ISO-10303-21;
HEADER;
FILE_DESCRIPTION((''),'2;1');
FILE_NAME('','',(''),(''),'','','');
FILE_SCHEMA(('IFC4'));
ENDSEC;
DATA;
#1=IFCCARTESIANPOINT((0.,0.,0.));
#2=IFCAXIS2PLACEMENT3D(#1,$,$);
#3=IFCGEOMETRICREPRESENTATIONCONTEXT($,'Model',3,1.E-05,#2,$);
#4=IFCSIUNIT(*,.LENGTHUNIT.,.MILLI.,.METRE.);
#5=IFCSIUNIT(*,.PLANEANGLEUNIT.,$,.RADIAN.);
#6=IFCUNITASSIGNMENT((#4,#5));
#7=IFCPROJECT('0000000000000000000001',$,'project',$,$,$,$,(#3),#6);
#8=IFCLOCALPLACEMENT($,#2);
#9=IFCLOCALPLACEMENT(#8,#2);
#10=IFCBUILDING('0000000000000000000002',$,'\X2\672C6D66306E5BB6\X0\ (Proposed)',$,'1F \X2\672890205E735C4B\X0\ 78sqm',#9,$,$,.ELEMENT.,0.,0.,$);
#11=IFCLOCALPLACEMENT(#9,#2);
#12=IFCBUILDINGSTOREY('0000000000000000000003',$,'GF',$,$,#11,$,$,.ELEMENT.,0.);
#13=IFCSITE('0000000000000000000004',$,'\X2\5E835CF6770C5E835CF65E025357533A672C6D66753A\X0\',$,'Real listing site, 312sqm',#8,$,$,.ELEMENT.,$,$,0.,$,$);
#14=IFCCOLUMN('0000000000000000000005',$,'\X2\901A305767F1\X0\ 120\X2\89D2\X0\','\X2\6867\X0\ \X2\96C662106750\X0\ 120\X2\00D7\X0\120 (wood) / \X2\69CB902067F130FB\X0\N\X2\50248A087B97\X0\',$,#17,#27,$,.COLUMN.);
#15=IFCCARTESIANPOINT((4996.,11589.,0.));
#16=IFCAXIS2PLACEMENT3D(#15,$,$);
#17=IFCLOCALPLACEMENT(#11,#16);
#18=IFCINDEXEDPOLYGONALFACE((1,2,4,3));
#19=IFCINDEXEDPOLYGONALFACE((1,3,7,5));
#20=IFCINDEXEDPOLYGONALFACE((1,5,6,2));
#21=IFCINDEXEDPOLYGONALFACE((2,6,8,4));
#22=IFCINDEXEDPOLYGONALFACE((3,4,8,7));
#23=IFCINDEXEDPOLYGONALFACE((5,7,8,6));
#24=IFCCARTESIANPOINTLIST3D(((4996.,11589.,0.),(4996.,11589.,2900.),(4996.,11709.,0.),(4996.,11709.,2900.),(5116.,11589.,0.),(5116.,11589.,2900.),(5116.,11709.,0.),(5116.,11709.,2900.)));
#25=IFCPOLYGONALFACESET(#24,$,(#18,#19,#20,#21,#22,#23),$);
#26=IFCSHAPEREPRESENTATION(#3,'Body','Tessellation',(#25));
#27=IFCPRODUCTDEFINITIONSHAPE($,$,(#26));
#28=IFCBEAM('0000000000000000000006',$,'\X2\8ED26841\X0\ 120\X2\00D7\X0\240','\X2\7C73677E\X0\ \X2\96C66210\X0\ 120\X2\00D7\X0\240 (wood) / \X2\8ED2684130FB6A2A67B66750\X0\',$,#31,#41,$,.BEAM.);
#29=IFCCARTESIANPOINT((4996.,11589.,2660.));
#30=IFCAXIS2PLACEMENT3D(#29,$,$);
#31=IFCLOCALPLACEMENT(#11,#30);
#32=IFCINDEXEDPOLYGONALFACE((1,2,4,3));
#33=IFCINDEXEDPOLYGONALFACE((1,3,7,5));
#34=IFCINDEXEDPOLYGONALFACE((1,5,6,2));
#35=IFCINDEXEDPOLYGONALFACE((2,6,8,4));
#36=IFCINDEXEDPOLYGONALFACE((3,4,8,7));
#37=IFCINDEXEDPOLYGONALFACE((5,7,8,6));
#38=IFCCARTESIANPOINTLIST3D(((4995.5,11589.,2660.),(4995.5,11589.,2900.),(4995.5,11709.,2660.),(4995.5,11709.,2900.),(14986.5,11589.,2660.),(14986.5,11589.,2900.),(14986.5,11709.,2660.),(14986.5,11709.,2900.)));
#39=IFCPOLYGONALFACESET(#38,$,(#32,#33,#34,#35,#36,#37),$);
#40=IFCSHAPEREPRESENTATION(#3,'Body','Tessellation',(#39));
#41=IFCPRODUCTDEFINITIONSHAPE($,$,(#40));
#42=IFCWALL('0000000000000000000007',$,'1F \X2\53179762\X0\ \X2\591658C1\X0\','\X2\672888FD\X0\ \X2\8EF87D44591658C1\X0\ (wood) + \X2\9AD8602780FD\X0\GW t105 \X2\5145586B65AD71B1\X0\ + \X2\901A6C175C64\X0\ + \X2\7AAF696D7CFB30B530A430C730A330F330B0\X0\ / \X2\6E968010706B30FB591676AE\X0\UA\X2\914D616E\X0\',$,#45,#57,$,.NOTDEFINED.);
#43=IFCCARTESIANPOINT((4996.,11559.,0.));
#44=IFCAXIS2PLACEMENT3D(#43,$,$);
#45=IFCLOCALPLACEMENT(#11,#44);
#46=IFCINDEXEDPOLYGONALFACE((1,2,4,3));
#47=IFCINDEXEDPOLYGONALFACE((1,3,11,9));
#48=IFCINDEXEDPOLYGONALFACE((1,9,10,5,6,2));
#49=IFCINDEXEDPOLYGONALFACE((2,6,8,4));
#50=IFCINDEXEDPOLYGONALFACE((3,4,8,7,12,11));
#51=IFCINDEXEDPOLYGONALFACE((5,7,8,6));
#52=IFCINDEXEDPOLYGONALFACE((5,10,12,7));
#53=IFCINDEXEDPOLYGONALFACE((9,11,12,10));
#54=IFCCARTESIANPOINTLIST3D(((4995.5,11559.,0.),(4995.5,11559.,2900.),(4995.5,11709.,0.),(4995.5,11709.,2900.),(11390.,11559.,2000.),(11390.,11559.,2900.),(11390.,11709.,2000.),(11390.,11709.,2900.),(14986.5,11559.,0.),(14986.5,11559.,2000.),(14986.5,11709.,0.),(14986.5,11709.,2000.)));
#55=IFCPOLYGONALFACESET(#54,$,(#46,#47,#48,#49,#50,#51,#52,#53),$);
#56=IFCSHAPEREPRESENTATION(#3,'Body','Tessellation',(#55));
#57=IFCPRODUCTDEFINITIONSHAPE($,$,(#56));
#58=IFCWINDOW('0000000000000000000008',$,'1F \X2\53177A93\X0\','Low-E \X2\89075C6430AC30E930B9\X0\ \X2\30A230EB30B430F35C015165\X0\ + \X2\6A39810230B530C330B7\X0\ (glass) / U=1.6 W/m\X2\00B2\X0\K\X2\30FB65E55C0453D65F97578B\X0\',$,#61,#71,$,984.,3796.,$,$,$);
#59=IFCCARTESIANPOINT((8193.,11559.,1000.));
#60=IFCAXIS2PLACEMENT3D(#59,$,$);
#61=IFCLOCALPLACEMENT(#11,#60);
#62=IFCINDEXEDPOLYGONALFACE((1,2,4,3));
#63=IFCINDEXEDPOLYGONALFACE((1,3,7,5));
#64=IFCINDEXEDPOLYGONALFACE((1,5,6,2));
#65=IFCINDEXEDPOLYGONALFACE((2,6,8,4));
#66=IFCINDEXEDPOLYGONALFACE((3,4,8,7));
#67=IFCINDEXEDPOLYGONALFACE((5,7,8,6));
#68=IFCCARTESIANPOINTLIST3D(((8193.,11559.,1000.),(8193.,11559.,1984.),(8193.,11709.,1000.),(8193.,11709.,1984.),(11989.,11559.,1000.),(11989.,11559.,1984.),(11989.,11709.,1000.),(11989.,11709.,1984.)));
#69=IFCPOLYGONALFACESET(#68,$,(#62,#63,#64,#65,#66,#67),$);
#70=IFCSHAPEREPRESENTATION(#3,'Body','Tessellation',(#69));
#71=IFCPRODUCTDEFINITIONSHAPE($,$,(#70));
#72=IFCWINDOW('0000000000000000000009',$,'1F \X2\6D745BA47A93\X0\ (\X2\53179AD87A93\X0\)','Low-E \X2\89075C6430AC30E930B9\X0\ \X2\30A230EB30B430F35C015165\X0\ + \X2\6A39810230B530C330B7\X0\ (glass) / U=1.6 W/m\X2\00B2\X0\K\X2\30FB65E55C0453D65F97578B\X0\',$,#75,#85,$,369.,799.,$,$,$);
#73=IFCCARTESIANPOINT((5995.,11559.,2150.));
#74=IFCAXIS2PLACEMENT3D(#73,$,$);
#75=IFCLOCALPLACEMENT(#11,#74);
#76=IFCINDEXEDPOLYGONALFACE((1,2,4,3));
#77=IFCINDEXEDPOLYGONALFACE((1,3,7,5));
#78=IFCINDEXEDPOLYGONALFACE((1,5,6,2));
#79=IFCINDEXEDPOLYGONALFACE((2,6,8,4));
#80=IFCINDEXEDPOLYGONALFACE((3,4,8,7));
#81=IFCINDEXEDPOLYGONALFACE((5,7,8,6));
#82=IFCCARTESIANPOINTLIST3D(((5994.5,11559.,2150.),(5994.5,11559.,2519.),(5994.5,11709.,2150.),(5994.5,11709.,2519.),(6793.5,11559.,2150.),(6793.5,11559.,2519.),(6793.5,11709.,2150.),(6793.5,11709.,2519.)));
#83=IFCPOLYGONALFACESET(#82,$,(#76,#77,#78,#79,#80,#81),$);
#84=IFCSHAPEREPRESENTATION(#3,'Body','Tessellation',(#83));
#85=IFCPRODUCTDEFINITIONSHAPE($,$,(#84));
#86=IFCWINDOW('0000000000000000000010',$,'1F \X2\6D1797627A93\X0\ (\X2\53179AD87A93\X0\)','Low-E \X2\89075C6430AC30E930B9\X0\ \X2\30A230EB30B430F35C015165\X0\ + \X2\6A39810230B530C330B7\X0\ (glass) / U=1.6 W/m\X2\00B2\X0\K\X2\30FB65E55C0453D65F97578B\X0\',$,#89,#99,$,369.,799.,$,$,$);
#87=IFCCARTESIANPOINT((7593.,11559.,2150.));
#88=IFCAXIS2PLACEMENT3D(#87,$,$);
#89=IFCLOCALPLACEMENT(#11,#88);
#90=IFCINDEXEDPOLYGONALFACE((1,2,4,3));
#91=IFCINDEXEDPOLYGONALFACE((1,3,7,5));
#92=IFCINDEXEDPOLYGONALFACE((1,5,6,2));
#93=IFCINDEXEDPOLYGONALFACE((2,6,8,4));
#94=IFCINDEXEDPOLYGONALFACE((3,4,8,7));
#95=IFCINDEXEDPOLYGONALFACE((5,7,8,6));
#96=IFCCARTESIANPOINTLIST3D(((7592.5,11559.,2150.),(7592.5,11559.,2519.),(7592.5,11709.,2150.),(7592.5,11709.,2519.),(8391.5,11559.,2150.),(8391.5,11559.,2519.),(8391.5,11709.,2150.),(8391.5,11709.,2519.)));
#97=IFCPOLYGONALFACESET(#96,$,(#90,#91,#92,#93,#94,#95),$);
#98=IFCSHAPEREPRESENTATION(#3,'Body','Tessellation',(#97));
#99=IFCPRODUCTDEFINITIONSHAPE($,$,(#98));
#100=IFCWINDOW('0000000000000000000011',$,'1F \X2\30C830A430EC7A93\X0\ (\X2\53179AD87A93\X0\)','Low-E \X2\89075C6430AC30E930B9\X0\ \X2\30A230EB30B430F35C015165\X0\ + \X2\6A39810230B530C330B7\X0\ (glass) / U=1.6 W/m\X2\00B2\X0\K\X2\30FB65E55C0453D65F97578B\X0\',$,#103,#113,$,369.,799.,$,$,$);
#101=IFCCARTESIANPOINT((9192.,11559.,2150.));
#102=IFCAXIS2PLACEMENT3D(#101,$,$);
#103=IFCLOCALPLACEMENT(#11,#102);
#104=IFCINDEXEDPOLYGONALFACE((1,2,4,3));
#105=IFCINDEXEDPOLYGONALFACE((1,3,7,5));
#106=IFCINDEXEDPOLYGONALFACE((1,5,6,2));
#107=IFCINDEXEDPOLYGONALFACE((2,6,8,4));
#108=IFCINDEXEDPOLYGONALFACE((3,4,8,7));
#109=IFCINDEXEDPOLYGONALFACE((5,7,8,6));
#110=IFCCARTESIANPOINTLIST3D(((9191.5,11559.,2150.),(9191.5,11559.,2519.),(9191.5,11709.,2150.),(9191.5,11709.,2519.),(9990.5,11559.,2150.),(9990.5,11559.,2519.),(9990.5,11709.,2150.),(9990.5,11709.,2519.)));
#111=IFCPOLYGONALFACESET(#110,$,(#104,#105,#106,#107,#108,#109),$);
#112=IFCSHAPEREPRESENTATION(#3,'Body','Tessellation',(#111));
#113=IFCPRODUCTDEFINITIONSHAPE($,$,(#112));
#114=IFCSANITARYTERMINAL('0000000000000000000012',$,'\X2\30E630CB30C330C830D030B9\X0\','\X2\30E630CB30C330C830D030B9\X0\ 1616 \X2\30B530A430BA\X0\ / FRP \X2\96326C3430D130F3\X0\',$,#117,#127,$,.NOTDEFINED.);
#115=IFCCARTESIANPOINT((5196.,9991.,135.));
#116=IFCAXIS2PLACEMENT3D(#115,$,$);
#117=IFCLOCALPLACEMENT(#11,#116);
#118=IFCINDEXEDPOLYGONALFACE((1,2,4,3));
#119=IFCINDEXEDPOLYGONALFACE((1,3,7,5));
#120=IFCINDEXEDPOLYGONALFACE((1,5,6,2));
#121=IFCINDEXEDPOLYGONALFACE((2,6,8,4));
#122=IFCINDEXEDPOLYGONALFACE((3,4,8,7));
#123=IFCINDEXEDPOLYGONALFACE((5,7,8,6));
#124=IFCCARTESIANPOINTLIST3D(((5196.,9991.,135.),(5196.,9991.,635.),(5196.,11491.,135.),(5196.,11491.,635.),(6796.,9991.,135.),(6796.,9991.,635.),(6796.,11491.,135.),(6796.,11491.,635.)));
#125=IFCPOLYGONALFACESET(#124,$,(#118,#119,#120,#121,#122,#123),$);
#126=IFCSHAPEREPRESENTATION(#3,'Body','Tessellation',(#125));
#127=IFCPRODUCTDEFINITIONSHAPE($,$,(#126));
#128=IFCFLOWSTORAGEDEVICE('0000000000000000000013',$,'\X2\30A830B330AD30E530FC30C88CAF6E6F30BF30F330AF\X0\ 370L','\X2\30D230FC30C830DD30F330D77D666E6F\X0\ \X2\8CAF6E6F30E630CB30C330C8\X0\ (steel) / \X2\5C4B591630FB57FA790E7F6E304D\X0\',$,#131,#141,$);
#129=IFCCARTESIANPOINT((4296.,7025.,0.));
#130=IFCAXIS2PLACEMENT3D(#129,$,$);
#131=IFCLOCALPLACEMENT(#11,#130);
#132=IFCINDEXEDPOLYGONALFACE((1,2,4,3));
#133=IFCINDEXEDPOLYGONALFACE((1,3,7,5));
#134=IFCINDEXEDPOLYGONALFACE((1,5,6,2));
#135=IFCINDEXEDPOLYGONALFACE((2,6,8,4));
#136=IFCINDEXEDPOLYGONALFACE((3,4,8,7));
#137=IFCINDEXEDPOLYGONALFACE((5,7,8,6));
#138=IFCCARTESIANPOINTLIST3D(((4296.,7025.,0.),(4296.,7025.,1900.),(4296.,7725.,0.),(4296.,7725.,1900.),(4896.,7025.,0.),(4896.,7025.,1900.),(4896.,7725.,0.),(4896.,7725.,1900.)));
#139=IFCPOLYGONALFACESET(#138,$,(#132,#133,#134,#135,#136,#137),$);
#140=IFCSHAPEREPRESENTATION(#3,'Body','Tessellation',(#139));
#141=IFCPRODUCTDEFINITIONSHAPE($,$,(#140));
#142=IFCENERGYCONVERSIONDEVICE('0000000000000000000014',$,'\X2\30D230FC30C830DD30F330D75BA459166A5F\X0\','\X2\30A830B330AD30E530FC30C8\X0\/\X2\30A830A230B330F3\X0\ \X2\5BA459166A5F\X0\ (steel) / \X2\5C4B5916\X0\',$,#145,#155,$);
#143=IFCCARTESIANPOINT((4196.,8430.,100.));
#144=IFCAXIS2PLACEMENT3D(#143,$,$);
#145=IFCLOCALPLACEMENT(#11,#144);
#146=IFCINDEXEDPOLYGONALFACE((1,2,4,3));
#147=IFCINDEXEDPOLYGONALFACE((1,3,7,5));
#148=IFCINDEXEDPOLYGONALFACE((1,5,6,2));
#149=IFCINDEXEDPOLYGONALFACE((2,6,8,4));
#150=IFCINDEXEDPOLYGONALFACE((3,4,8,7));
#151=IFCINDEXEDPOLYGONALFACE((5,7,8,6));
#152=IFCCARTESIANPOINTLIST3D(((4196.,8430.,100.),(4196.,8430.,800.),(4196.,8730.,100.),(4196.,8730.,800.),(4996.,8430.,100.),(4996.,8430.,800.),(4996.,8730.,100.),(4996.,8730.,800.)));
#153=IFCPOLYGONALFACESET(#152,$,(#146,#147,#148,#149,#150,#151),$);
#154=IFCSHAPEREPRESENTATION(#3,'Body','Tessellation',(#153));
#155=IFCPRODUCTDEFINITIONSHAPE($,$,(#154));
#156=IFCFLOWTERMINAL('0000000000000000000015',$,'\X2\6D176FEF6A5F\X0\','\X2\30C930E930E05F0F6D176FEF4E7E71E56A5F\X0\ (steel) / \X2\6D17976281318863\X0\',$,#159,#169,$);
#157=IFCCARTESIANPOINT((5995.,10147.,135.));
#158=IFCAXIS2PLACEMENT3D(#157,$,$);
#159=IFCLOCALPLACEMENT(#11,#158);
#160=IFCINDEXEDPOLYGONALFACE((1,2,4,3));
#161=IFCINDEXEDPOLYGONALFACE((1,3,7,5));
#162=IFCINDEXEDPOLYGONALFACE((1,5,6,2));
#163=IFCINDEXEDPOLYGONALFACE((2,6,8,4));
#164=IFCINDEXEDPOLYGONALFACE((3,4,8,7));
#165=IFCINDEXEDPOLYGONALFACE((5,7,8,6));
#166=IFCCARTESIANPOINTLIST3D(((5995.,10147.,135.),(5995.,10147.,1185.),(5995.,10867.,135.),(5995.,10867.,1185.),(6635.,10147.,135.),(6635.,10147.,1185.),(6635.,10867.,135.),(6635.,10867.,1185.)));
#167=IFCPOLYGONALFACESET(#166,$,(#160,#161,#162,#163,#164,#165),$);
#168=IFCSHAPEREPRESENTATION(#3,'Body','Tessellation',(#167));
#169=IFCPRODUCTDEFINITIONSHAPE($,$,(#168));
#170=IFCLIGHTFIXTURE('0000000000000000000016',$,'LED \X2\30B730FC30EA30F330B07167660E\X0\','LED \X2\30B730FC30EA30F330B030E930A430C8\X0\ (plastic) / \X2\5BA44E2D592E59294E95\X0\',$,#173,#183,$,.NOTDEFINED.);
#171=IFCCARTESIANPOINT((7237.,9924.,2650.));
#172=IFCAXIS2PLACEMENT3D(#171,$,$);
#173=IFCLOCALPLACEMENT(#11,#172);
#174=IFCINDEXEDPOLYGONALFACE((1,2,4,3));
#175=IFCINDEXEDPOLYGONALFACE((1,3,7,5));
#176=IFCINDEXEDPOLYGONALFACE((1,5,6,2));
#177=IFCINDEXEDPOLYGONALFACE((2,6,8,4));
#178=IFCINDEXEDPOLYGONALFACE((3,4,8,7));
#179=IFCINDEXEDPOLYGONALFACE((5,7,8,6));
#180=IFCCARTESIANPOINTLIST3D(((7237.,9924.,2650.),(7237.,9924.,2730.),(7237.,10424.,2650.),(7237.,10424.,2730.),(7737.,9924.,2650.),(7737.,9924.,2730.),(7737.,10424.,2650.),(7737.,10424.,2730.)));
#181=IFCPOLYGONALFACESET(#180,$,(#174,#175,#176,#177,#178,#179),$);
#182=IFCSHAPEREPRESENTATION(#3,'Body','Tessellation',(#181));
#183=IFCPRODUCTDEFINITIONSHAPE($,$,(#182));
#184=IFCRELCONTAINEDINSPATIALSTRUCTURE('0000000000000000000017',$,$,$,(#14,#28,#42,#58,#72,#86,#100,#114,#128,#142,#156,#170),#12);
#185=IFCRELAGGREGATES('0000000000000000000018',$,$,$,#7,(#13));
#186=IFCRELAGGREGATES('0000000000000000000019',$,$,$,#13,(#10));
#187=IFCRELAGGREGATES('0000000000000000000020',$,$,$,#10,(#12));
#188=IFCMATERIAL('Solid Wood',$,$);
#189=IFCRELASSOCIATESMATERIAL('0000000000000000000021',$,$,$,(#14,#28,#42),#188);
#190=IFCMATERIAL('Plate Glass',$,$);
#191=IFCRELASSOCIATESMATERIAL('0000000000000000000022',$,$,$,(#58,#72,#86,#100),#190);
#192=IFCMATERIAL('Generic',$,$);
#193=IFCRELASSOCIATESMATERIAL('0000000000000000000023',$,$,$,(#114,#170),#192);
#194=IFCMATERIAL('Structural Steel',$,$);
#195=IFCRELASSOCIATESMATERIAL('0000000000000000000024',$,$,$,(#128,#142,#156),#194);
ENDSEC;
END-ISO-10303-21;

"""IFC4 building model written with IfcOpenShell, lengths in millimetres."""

from ifc_helpers import new_model, si_unit, frame, frame_2d, origin, place, context, project, spatial, rectangle, extrude, material, element, fill, save


model = new_model("IFC4")

# Units and contexts
model_context = context("Model", 3, precision=1e-05, world=origin())
ifc_project = project(units=[si_unit("LENGTHUNIT", "METRE", prefix="MILLI"), si_unit("PLANEANGLEUNIT", "RADIAN")], contexts=[model_context])

# Site, building, storey
site_placement = place(None, origin())
site = spatial("IfcSite", under=ifc_project, at=site_placement, Name="広島県広島市南区本浦町", ObjectType="Real listing site, 312sqm", CompositionType="ELEMENT", RefElevation=0.0)
building_placement = place(site_placement, origin())
building = spatial("IfcBuilding", under=site, at=building_placement, Name="本浦の家 (Proposed)", ObjectType="1F 木造平屋 78sqm", CompositionType="ELEMENT", ElevationOfRefHeight=0.0, ElevationOfTerrain=0.0)
storey_placement = place(building_placement, origin())
storey = spatial("IfcBuildingStorey", under=building, at=storey_placement, Name="GF", CompositionType="ELEMENT", Elevation=0.0)

# Column
ifc_material_1 = material(Name="Solid Wood")
column_1_placement = place(storey_placement, frame((4996.0, 11589.0, 0.0)))
element("IfcColumn", 1, at=column_1_placement, inside=storey, material=ifc_material_1, Name="通し柱 120角", Description="桧 集成材 120×120 (wood) / 構造柱・N値計算", PredefinedType="COLUMN", context=model_context, shape_type="SweptSolid", body=[
    extrude(rectangle(XDim=120.0, YDim=120.0, at=frame_2d((60.0, 60.0))), frame((4996.0, 11589.0, 0.0)), (0.0, 0.0, 1.0), 2900.0),
])

# Beam
beam_1_placement = place(storey_placement, frame((4996.0, 11589.0, 2660.0)))
element("IfcBeam", 2, at=beam_1_placement, inside=storey, material=ifc_material_1, Name="軒桁 120×240", Description="米松 集成 120×240 (wood) / 軒桁・横架材", PredefinedType="BEAM", context=model_context, shape_type="SweptSolid", body=[
    extrude(rectangle(XDim=9991.0, YDim=120.0, at=frame_2d((4995.0, 60.0))), frame((4996.0, 11589.0, 2660.0)), (0.0, 0.0, 1.0), 240.0),
])

# Wall, openings, windows
wall_1_placement = place(storey_placement, frame((4996.0, 11559.0, 0.0)))
wall_1 = element("IfcWall", 3, at=wall_1_placement, inside=storey, material=ifc_material_1, Name="1F 北面 外壁", Description="木製 軸組外壁 (wood) + 高性能GW t105 充填断熱 + 通気層 + 窯業系サイディング / 準耐火・外皮UA配慮", PredefinedType="NOTDEFINED", context=model_context, shape_type="SweptSolid", body=[
    extrude(rectangle(XDim=9991.0, YDim=150.0, at=frame_2d((4995.0, 75.0))), frame((4996.0, 11559.0, 0.0)), (0.0, 0.0, 1.0), 2900.0),
])
opening_1_placement = place(storey_placement, frame((8193.0, 11559.0, 1000.0)))
opening_1 = element("IfcOpeningElement", 4, at=opening_1_placement, cuts=wall_1, PredefinedType="NOTDEFINED", context=model_context, shape_type="SweptSolid", body=[
    extrude(rectangle(XDim=3796.0, YDim=150.0, at=frame_2d((1898.0, 75.0))), frame((8193.0, 11559.0, 1000.0)), (0.0, 0.0, 1.0), 984.0),
])
opening_2_placement = place(storey_placement, frame((5995.0, 11559.0, 2150.0)))
opening_2 = element("IfcOpeningElement", 5, at=opening_2_placement, cuts=wall_1, PredefinedType="NOTDEFINED", context=model_context, shape_type="SweptSolid", body=[
    extrude(rectangle(XDim=799.0, YDim=150.0, at=frame_2d((399.0, 75.0))), frame((5995.0, 11559.0, 2150.0)), (0.0, 0.0, 1.0), 369.0),
])
opening_3_placement = place(storey_placement, frame((7593.0, 11559.0, 2150.0)))
opening_3 = element("IfcOpeningElement", 6, at=opening_3_placement, cuts=wall_1, PredefinedType="NOTDEFINED", context=model_context, shape_type="SweptSolid", body=[
    extrude(rectangle(XDim=799.0, YDim=150.0, at=frame_2d((399.0, 75.0))), frame((7593.0, 11559.0, 2150.0)), (0.0, 0.0, 1.0), 369.0),
])
opening_4_placement = place(storey_placement, frame((9192.0, 11559.0, 2150.0)))
opening_4 = element("IfcOpeningElement", 7, at=opening_4_placement, cuts=wall_1, PredefinedType="NOTDEFINED", context=model_context, shape_type="SweptSolid", body=[
    extrude(rectangle(XDim=799.0, YDim=150.0, at=frame_2d((399.0, 75.0))), frame((9192.0, 11559.0, 2150.0)), (0.0, 0.0, 1.0), 369.0),
])
ifc_material_2 = material(Name="Plate Glass")
window_1_placement = place(storey_placement, frame((8193.0, 11559.0, 1000.0)))
window_1 = element("IfcWindow", 8, at=window_1_placement, inside=storey, material=ifc_material_2, Name="1F 北窓", Description="Low-E 複層ガラス アルゴン封入 + 樹脂サッシ (glass) / U=1.6 W/m²K・日射取得型", OverallHeight=984.0, OverallWidth=3796.0, context=model_context, shape_type="SweptSolid", body=[
    extrude(rectangle(XDim=3796.0, YDim=150.0, at=frame_2d((1898.0, 75.0))), frame((8193.0, 11559.0, 1000.0)), (0.0, 0.0, 1.0), 984.0),
])
fill(opening_1, window_1)
window_2_placement = place(storey_placement, frame((5995.0, 11559.0, 2150.0)))
window_2 = element("IfcWindow", 9, at=window_2_placement, inside=storey, material=ifc_material_2, Name="1F 浴室窓 (北高窓)", Description="Low-E 複層ガラス アルゴン封入 + 樹脂サッシ (glass) / U=1.6 W/m²K・日射取得型", OverallHeight=369.0, OverallWidth=799.0, context=model_context, shape_type="SweptSolid", body=[
    extrude(rectangle(XDim=799.0, YDim=150.0, at=frame_2d((399.0, 75.0))), frame((5995.0, 11559.0, 2150.0)), (0.0, 0.0, 1.0), 369.0),
])
fill(opening_2, window_2)
window_3_placement = place(storey_placement, frame((7593.0, 11559.0, 2150.0)))
window_3 = element("IfcWindow", 10, at=window_3_placement, inside=storey, material=ifc_material_2, Name="1F 洗面窓 (北高窓)", Description="Low-E 複層ガラス アルゴン封入 + 樹脂サッシ (glass) / U=1.6 W/m²K・日射取得型", OverallHeight=369.0, OverallWidth=799.0, context=model_context, shape_type="SweptSolid", body=[
    extrude(rectangle(XDim=799.0, YDim=150.0, at=frame_2d((399.0, 75.0))), frame((7593.0, 11559.0, 2150.0)), (0.0, 0.0, 1.0), 369.0),
])
fill(opening_3, window_3)
window_4_placement = place(storey_placement, frame((9192.0, 11559.0, 2150.0)))
window_4 = element("IfcWindow", 11, at=window_4_placement, inside=storey, material=ifc_material_2, Name="1F トイレ窓 (北高窓)", Description="Low-E 複層ガラス アルゴン封入 + 樹脂サッシ (glass) / U=1.6 W/m²K・日射取得型", OverallHeight=369.0, OverallWidth=799.0, context=model_context, shape_type="SweptSolid", body=[
    extrude(rectangle(XDim=799.0, YDim=150.0, at=frame_2d((399.0, 75.0))), frame((9192.0, 11559.0, 2150.0)), (0.0, 0.0, 1.0), 369.0),
])
fill(opening_4, window_4)

# Shared definitions
ifc_material_3 = material(Name="Structural Steel")

# Sanitary terminal
ifc_material_4 = material(Name="Generic")
sanitary_terminal_placement = place(storey_placement, frame((5196.0, 9991.0, 135.0)))
element("IfcSanitaryTerminal", 12, at=sanitary_terminal_placement, inside=storey, material=ifc_material_4, Name="ユニットバス", Description="ユニットバス 1616 サイズ / FRP 防水パン", PredefinedType="NOTDEFINED", context=model_context, shape_type="SweptSolid", body=[
    extrude(rectangle(XDim=1600.0, YDim=1500.0, at=frame_2d((800.0, 750.0))), frame((5196.0, 9991.0, 135.0)), (0.0, 0.0, 1.0), 500.0),
])

# Flow storage device
flow_storage_device_placement = place(storey_placement, frame((4296.0, 7025.0, 0.0)))
element("IfcFlowStorageDevice", 13, at=flow_storage_device_placement, inside=storey, material=ifc_material_3, Name="エコキュート貯湯タンク 370L", Description="ヒートポンプ給湯 貯湯ユニット (steel) / 屋外・基礎置き", context=model_context, shape_type="SweptSolid", body=[
    extrude(rectangle(XDim=600.0, YDim=700.0, at=frame_2d((300.0, 350.0))), frame((4296.0, 7025.0, 0.0)), (0.0, 0.0, 1.0), 1900.0),
])

# Energy conversion device
energy_conversion_device_placement = place(storey_placement, frame((4196.0, 8430.0, 100.0)))
element("IfcEnergyConversionDevice", 14, at=energy_conversion_device_placement, inside=storey, material=ifc_material_3, Name="ヒートポンプ室外機", Description="エコキュート/エアコン 室外機 (steel) / 屋外", context=model_context, shape_type="SweptSolid", body=[
    extrude(rectangle(XDim=800.0, YDim=300.0, at=frame_2d((400.0, 150.0))), frame((4196.0, 8430.0, 100.0)), (0.0, 0.0, 1.0), 700.0),
])

# Flow terminal
flow_terminal_placement = place(storey_placement, frame((5995.0, 10147.0, 135.0)))
element("IfcFlowTerminal", 15, at=flow_terminal_placement, inside=storey, material=ifc_material_3, Name="洗濯機", Description="ドラム式洗濯乾燥機 (steel) / 洗面脱衣", context=model_context, shape_type="SweptSolid", body=[
    extrude(rectangle(XDim=640.0, YDim=720.0, at=frame_2d((320.0, 360.0))), frame((5995.0, 10147.0, 135.0)), (0.0, 0.0, 1.0), 1050.0),
])

# Light fixture
light_fixture_placement = place(storey_placement, frame((7237.0, 9924.0, 2650.0)))
element("IfcLightFixture", 16, at=light_fixture_placement, inside=storey, material=ifc_material_4, Name="LED シーリング照明", Description="LED シーリングライト (plastic) / 室中央天井", PredefinedType="NOTDEFINED", context=model_context, shape_type="SweptSolid", body=[
    extrude(rectangle(XDim=500.0, YDim=500.0, at=frame_2d((250.0, 250.0))), frame((7237.0, 9924.0, 2650.0)), (0.0, 0.0, 1.0), 80.0),
])

save(model, "model.ifc")
